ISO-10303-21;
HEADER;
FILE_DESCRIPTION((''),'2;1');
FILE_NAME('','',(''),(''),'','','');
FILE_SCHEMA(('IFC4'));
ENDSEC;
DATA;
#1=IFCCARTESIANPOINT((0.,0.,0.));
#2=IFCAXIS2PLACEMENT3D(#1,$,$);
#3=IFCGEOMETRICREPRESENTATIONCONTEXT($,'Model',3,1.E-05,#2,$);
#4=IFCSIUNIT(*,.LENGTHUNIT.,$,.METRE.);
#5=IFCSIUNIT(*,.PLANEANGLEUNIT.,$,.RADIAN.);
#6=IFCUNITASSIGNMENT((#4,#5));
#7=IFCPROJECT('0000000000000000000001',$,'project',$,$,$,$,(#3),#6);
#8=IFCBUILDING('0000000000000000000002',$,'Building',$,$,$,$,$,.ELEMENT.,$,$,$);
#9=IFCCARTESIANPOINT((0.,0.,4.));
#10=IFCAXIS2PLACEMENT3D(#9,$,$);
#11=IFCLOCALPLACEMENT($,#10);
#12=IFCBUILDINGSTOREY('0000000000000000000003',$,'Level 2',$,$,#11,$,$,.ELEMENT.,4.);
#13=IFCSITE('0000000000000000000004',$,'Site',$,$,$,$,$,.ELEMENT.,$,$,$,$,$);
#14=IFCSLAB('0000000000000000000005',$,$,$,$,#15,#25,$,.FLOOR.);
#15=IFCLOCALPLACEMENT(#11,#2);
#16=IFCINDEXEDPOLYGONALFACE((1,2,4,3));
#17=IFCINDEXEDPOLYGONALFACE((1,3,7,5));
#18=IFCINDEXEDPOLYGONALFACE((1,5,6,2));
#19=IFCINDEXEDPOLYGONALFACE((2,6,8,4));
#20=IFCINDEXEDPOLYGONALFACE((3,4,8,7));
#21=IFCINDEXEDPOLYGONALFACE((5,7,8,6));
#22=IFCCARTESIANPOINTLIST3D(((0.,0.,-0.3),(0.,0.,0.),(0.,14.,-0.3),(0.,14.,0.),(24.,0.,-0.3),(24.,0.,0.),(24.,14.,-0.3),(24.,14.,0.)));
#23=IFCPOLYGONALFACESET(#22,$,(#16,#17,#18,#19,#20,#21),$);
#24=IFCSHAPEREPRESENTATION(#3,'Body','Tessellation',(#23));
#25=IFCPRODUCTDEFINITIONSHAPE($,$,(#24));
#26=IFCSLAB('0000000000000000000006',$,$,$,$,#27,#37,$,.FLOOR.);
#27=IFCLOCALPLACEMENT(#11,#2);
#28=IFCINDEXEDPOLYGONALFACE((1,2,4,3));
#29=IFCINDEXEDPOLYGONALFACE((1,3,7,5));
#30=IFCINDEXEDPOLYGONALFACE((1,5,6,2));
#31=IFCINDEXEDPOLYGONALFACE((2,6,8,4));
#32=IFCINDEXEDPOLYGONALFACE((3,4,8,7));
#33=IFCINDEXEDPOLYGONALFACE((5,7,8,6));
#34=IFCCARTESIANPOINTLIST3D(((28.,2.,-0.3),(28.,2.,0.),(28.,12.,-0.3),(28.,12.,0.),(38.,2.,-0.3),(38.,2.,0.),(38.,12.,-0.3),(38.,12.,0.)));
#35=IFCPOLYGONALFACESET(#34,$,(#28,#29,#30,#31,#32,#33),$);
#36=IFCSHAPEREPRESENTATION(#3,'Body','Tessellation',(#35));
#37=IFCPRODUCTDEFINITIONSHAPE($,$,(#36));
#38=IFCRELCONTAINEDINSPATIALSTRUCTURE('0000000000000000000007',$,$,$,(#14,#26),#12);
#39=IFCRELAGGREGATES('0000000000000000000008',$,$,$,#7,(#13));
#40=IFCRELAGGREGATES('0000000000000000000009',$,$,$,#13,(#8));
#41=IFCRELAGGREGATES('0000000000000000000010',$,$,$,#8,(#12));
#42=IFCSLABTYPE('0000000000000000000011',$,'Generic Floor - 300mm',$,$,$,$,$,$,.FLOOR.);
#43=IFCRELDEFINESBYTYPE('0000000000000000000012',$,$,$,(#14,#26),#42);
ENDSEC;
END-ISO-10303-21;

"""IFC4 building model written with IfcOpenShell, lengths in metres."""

from ifc_helpers import new_model, si_unit, frame, origin, place, context, project, spatial, polyline, outline, extrude, type_object, element, save


model = new_model("IFC4")

# Units and contexts
model_context = context("Model", 3, precision=1e-05, world=origin())
ifc_project = project(units=[si_unit("LENGTHUNIT", "METRE"), si_unit("PLANEANGLEUNIT", "RADIAN")], contexts=[model_context])

# Site, building, storey
site = spatial("IfcSite", under=ifc_project, Name="Site", CompositionType="ELEMENT")
building = spatial("IfcBuilding", under=site, Name="Building", CompositionType="ELEMENT")
storey_placement = place(None, frame((0.0, 0.0, 4.0)))
storey = spatial("IfcBuildingStorey", under=building, at=storey_placement, Name="Level 2", CompositionType="ELEMENT", Elevation=4.0)

# Slabs
slab_type = type_object("IfcSlabType", Name="Generic Floor - 300mm", PredefinedType="FLOOR")
slab_1_placement = place(None, frame((0.0, 0.0, 4.0)))
element("IfcSlab", 1, at=slab_1_placement, inside=storey, type_object=slab_type, PredefinedType="FLOOR", context=model_context, shape_type="SweptSolid", body=[
    extrude(outline(polyline([(0.0, 14.0), (0.0, 0.0), (24.0, 0.0), (24.0, 14.0), (0.0, 14.0)])), origin(), (0.0, 0.0, -1.0), 0.3),
])
slab_2_placement = place(None, frame((0.0, 0.0, 4.0)))
element("IfcSlab", 2, at=slab_2_placement, inside=storey, type_object=slab_type, PredefinedType="FLOOR", context=model_context, shape_type="SweptSolid", body=[
    extrude(outline(polyline([(28.0, 12.0), (28.0, 2.0), (38.0, 2.0), (38.0, 12.0), (28.0, 12.0)])), origin(), (0.0, 0.0, -1.0), 0.3),
])

save(model, "model.ifc")
